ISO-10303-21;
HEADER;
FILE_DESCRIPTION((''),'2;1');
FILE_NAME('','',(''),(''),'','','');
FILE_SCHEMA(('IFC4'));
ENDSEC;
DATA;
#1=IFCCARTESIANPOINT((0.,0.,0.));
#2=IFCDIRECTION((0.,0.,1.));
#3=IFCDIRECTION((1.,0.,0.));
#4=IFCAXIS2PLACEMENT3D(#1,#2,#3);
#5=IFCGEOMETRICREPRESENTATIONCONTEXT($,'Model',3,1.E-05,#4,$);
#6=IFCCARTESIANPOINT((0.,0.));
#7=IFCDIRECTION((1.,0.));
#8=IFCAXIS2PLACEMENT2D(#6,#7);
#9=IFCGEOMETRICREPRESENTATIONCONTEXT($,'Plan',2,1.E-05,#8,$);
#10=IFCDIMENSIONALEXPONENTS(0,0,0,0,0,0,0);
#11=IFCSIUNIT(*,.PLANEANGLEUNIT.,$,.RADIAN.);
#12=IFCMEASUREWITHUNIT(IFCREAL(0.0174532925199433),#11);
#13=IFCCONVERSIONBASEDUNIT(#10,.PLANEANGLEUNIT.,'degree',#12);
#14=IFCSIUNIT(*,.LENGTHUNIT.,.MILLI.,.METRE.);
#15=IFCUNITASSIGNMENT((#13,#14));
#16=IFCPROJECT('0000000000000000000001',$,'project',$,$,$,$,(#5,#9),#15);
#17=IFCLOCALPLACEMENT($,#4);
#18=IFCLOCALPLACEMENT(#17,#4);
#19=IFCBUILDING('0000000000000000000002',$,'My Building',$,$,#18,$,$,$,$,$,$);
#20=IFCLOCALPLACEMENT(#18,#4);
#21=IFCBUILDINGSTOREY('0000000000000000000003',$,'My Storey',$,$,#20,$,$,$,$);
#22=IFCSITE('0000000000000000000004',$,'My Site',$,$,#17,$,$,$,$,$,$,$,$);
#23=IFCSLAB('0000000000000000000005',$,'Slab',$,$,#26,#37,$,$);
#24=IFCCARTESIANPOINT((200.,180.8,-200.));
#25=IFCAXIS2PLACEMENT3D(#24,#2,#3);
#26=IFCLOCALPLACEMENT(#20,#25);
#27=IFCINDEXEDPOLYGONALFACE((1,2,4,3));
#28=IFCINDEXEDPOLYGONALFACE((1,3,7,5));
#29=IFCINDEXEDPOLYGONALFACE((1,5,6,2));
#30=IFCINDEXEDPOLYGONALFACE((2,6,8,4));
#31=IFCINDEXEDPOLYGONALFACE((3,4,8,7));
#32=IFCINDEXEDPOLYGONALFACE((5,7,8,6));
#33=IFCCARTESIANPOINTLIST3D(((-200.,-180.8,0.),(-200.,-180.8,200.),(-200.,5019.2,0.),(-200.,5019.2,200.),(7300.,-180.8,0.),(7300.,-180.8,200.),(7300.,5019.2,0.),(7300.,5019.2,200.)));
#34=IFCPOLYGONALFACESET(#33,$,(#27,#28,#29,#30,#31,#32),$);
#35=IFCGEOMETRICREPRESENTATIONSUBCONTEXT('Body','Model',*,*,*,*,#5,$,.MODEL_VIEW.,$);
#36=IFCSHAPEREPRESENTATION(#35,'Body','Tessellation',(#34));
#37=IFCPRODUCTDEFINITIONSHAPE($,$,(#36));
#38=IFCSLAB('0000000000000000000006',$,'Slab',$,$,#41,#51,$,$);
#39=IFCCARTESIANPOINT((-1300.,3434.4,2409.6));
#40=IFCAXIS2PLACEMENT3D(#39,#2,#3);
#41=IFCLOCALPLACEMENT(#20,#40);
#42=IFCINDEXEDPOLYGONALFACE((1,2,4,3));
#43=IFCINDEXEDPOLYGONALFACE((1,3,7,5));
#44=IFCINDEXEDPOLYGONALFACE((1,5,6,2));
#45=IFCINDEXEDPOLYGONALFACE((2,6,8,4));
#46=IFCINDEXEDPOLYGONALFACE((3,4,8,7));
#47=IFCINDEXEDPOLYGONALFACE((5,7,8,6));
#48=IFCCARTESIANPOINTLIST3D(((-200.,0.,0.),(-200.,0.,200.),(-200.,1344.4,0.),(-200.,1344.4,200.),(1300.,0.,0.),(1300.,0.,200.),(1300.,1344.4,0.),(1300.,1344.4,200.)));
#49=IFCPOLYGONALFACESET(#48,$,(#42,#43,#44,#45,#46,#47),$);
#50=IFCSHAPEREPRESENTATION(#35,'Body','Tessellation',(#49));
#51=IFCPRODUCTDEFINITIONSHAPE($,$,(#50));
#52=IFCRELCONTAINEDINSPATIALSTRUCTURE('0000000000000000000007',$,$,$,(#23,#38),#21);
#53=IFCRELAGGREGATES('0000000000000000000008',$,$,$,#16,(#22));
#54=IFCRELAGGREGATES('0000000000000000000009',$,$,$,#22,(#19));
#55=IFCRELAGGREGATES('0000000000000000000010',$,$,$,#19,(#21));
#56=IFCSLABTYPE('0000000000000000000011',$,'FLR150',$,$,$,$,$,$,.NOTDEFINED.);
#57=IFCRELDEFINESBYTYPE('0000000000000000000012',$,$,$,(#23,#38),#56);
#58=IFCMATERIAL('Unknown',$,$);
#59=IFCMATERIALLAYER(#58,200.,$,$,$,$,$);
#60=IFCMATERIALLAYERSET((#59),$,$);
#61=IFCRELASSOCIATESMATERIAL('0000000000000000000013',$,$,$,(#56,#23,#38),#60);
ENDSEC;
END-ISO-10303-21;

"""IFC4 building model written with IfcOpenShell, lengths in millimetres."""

from ifc_helpers import new_model, entity, si_unit, converted_unit, frame, origin_with_axes, origin_2d_with_axis, place, context, subcontext, project, spatial, line, indexed_curve, outline, extrude, material, layer, layer_set, layer_usage, type_object, element, save


model = new_model("IFC4")

# Units and contexts
model_context = context("Model", 3, precision=1e-05, world=origin_with_axes())
plan_context = context("Plan", 2, precision=1e-05, world=origin_2d_with_axis())
body_context = subcontext(model_context, "Body", "Model", "MODEL_VIEW")
ifc_project = project(units=[converted_unit("PLANEANGLEUNIT", "degree", entity("IfcReal", 0.0174532925199433), si_unit("PLANEANGLEUNIT", "RADIAN"), dimensions=[0, 0, 0, 0, 0, 0, 0]), si_unit("LENGTHUNIT", "METRE", prefix="MILLI")], contexts=[model_context, plan_context])

# Site, building, storey
site_placement = place(None, origin_with_axes())
site = spatial("IfcSite", under=ifc_project, at=site_placement, Name="My Site")
building_placement = place(site_placement, origin_with_axes())
building = spatial("IfcBuilding", under=site, at=building_placement, Name="My Building")
storey_placement = place(building_placement, origin_with_axes())
storey = spatial("IfcBuildingStorey", under=building, at=storey_placement, Name="My Storey")

# Shared definitions
ifc_material = material(Name="Unknown")

# Slabs
ifc_layer_1 = layer(ifc_material, 200.0)
ifc_layer_set_1 = layer_set([ifc_layer_1])
ifc_layer_usage_1 = layer_usage(ifc_layer_set_1, "AXIS3", "POSITIVE", 0.0)
slab_type = type_object("IfcSlabType", Name="FLR150", PredefinedType="NOTDEFINED", material=ifc_layer_set_1)
slab_1_placement = place(storey_placement, frame((200.0, 180.8, -200.0), z_axis=(0.0, 0.0, 1.0), x_axis=(1.0, 0.0, 0.0)))
element("IfcSlab", 1, at=slab_1_placement, inside=storey, type_object=slab_type, material=ifc_layer_usage_1, Name="Slab", context=body_context, shape_type="SweptSolid", body=[
    extrude(outline(indexed_curve([(7300.0, 5019.2), (7300.0, -180.8), (-200.0, -180.8), (-200.0, 5019.2)], segments=[line(3, 2), line(2, 1), line(1, 4), line(4, 3)], self_intersect=False)), None, (0.0, 0.0, 1.0), 200.0),
])
ifc_layer_usage_2 = layer_usage(ifc_layer_set_1, "AXIS3", "POSITIVE", 0.0)
slab_2_placement = place(storey_placement, frame((-1300.0, 3434.4, 2409.6), z_axis=(0.0, 0.0, 1.0), x_axis=(1.0, 0.0, 0.0)))
element("IfcSlab", 2, at=slab_2_placement, inside=storey, type_object=slab_type, material=ifc_layer_usage_2, Name="Slab", context=body_context, shape_type="SweptSolid", body=[
    extrude(outline(indexed_curve([(-200.0, 1344.4), (1300.0, 1344.4), (1300.0, 0.0), (-200.0, 0.0)], segments=[line(4, 1), line(1, 2), line(2, 3), line(3, 4)], self_intersect=False)), None, (0.0, 0.0, 1.0), 200.0),
])

save(model, "model.ifc")
